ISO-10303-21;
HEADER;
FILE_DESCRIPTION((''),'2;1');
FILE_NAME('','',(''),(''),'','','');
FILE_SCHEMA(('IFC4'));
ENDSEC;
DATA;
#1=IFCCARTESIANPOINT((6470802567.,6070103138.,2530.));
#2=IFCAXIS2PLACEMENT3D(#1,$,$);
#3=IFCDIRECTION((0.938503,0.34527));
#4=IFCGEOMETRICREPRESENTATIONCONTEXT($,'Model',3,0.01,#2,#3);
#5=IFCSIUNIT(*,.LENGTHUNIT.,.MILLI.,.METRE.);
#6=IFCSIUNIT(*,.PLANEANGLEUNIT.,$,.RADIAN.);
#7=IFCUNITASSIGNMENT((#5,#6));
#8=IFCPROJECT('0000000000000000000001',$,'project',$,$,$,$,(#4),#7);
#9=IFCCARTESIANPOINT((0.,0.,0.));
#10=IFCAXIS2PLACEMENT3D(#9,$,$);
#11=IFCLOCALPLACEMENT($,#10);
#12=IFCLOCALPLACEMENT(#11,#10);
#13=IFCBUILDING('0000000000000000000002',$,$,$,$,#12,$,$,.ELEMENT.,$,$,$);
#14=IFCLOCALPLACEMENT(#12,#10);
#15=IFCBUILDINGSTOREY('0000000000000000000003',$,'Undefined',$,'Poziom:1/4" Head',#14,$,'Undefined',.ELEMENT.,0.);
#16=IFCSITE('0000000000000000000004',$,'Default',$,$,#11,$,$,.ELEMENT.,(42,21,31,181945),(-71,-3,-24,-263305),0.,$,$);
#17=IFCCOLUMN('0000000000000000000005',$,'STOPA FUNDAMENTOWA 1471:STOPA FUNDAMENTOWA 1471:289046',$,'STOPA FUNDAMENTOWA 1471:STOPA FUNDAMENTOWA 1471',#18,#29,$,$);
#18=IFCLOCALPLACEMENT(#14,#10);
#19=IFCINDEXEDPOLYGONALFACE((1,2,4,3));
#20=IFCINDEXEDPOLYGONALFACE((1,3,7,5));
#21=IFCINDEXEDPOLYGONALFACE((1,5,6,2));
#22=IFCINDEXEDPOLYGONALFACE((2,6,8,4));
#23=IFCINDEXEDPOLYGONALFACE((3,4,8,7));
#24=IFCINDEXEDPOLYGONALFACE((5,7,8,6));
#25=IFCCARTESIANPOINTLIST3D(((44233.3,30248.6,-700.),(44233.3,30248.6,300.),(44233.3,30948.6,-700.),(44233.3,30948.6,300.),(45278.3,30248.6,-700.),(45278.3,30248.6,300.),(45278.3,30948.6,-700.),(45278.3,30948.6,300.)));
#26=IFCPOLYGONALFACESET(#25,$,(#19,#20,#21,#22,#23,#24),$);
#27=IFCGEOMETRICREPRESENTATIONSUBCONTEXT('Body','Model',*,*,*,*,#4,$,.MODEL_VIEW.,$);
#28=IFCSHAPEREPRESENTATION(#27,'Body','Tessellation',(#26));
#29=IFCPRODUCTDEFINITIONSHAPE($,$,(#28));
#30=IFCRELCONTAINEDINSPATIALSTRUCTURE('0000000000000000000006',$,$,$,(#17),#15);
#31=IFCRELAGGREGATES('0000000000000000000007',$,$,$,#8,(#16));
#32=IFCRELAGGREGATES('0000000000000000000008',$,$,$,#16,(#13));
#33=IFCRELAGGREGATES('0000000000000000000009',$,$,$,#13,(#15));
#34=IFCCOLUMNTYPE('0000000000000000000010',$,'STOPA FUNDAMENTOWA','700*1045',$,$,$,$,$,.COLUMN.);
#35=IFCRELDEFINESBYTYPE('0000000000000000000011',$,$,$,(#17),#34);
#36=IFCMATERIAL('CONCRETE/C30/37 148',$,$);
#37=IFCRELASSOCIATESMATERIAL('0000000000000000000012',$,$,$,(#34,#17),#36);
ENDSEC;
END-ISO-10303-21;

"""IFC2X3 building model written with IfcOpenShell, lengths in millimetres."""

from ifc_helpers import new_model, si_unit, direction, frame, origin, origin_2d_with_axis, place, context, subcontext, project, spatial, rectangle, extrude, source, transform, mapped, material, type_object, type_shapes, element, save


model = new_model("IFC2X3")

# Units and contexts
model_context = context("Model", 3, precision=0.01, world=frame((6470802567.0, 6070103138.0, 2530.0)), true_north=direction((0.938503, 0.34527)))
body_context = subcontext(model_context, "Body", "Model", "MODEL_VIEW")
ifc_project = project(units=[si_unit("LENGTHUNIT", "METRE", prefix="MILLI"), si_unit("PLANEANGLEUNIT", "RADIAN")], contexts=[model_context])

# Site, building, storey
site_placement = place(None, origin())
site = spatial("IfcSite", under=ifc_project, at=site_placement, Name="Default", CompositionType="ELEMENT", RefLatitude=(42, 21, 31, 181945), RefLongitude=(-71, -3, -24, -263305), RefElevation=0.0)
building_placement = place(site_placement, origin())
building = spatial("IfcBuilding", under=site, at=building_placement, CompositionType="ELEMENT")
storey_placement = place(building_placement, origin())
storey = spatial("IfcBuildingStorey", under=building, at=storey_placement, Name="Undefined", ObjectType="Poziom:1/4\" Head", LongName="Undefined", CompositionType="ELEMENT", Elevation=0.0)

# Shared definitions
ifc_material_1 = material(Name="CONCRETE/C30/37 148")

# Column
column_type_1 = type_object("IfcColumnType", Name="STOPA FUNDAMENTOWA", Description="700*1045", PredefinedType="COLUMN", material=ifc_material_1)
shared_shape_1 = source(origin(), body_context, "Body", "SweptSolid", [
    extrude(rectangle(XDim=700.0, YDim=1045.0, at=origin_2d_with_axis()), frame((44755.8, 30598.6, -700.0), z_axis=(0.0, 0.0, 1.0), x_axis=(0.0, 1.0, 0.0)), (0.0, 0.0, 1.0), 1000.0),
])
type_shapes(column_type_1, [shared_shape_1])
column_1_placement = place(storey_placement, origin())
element("IfcColumn", 1, at=column_1_placement, inside=storey, type_object=column_type_1, material=ifc_material_1, Name="STOPA FUNDAMENTOWA 1471:STOPA FUNDAMENTOWA 1471:289046", ObjectType="STOPA FUNDAMENTOWA 1471:STOPA FUNDAMENTOWA 1471", context=body_context, shape_type="MappedRepresentation", body=[
    mapped(shared_shape_1, transform((0.0, 0.0, 0.0), scale=1.0)),
])

save(model, "model.ifc")
